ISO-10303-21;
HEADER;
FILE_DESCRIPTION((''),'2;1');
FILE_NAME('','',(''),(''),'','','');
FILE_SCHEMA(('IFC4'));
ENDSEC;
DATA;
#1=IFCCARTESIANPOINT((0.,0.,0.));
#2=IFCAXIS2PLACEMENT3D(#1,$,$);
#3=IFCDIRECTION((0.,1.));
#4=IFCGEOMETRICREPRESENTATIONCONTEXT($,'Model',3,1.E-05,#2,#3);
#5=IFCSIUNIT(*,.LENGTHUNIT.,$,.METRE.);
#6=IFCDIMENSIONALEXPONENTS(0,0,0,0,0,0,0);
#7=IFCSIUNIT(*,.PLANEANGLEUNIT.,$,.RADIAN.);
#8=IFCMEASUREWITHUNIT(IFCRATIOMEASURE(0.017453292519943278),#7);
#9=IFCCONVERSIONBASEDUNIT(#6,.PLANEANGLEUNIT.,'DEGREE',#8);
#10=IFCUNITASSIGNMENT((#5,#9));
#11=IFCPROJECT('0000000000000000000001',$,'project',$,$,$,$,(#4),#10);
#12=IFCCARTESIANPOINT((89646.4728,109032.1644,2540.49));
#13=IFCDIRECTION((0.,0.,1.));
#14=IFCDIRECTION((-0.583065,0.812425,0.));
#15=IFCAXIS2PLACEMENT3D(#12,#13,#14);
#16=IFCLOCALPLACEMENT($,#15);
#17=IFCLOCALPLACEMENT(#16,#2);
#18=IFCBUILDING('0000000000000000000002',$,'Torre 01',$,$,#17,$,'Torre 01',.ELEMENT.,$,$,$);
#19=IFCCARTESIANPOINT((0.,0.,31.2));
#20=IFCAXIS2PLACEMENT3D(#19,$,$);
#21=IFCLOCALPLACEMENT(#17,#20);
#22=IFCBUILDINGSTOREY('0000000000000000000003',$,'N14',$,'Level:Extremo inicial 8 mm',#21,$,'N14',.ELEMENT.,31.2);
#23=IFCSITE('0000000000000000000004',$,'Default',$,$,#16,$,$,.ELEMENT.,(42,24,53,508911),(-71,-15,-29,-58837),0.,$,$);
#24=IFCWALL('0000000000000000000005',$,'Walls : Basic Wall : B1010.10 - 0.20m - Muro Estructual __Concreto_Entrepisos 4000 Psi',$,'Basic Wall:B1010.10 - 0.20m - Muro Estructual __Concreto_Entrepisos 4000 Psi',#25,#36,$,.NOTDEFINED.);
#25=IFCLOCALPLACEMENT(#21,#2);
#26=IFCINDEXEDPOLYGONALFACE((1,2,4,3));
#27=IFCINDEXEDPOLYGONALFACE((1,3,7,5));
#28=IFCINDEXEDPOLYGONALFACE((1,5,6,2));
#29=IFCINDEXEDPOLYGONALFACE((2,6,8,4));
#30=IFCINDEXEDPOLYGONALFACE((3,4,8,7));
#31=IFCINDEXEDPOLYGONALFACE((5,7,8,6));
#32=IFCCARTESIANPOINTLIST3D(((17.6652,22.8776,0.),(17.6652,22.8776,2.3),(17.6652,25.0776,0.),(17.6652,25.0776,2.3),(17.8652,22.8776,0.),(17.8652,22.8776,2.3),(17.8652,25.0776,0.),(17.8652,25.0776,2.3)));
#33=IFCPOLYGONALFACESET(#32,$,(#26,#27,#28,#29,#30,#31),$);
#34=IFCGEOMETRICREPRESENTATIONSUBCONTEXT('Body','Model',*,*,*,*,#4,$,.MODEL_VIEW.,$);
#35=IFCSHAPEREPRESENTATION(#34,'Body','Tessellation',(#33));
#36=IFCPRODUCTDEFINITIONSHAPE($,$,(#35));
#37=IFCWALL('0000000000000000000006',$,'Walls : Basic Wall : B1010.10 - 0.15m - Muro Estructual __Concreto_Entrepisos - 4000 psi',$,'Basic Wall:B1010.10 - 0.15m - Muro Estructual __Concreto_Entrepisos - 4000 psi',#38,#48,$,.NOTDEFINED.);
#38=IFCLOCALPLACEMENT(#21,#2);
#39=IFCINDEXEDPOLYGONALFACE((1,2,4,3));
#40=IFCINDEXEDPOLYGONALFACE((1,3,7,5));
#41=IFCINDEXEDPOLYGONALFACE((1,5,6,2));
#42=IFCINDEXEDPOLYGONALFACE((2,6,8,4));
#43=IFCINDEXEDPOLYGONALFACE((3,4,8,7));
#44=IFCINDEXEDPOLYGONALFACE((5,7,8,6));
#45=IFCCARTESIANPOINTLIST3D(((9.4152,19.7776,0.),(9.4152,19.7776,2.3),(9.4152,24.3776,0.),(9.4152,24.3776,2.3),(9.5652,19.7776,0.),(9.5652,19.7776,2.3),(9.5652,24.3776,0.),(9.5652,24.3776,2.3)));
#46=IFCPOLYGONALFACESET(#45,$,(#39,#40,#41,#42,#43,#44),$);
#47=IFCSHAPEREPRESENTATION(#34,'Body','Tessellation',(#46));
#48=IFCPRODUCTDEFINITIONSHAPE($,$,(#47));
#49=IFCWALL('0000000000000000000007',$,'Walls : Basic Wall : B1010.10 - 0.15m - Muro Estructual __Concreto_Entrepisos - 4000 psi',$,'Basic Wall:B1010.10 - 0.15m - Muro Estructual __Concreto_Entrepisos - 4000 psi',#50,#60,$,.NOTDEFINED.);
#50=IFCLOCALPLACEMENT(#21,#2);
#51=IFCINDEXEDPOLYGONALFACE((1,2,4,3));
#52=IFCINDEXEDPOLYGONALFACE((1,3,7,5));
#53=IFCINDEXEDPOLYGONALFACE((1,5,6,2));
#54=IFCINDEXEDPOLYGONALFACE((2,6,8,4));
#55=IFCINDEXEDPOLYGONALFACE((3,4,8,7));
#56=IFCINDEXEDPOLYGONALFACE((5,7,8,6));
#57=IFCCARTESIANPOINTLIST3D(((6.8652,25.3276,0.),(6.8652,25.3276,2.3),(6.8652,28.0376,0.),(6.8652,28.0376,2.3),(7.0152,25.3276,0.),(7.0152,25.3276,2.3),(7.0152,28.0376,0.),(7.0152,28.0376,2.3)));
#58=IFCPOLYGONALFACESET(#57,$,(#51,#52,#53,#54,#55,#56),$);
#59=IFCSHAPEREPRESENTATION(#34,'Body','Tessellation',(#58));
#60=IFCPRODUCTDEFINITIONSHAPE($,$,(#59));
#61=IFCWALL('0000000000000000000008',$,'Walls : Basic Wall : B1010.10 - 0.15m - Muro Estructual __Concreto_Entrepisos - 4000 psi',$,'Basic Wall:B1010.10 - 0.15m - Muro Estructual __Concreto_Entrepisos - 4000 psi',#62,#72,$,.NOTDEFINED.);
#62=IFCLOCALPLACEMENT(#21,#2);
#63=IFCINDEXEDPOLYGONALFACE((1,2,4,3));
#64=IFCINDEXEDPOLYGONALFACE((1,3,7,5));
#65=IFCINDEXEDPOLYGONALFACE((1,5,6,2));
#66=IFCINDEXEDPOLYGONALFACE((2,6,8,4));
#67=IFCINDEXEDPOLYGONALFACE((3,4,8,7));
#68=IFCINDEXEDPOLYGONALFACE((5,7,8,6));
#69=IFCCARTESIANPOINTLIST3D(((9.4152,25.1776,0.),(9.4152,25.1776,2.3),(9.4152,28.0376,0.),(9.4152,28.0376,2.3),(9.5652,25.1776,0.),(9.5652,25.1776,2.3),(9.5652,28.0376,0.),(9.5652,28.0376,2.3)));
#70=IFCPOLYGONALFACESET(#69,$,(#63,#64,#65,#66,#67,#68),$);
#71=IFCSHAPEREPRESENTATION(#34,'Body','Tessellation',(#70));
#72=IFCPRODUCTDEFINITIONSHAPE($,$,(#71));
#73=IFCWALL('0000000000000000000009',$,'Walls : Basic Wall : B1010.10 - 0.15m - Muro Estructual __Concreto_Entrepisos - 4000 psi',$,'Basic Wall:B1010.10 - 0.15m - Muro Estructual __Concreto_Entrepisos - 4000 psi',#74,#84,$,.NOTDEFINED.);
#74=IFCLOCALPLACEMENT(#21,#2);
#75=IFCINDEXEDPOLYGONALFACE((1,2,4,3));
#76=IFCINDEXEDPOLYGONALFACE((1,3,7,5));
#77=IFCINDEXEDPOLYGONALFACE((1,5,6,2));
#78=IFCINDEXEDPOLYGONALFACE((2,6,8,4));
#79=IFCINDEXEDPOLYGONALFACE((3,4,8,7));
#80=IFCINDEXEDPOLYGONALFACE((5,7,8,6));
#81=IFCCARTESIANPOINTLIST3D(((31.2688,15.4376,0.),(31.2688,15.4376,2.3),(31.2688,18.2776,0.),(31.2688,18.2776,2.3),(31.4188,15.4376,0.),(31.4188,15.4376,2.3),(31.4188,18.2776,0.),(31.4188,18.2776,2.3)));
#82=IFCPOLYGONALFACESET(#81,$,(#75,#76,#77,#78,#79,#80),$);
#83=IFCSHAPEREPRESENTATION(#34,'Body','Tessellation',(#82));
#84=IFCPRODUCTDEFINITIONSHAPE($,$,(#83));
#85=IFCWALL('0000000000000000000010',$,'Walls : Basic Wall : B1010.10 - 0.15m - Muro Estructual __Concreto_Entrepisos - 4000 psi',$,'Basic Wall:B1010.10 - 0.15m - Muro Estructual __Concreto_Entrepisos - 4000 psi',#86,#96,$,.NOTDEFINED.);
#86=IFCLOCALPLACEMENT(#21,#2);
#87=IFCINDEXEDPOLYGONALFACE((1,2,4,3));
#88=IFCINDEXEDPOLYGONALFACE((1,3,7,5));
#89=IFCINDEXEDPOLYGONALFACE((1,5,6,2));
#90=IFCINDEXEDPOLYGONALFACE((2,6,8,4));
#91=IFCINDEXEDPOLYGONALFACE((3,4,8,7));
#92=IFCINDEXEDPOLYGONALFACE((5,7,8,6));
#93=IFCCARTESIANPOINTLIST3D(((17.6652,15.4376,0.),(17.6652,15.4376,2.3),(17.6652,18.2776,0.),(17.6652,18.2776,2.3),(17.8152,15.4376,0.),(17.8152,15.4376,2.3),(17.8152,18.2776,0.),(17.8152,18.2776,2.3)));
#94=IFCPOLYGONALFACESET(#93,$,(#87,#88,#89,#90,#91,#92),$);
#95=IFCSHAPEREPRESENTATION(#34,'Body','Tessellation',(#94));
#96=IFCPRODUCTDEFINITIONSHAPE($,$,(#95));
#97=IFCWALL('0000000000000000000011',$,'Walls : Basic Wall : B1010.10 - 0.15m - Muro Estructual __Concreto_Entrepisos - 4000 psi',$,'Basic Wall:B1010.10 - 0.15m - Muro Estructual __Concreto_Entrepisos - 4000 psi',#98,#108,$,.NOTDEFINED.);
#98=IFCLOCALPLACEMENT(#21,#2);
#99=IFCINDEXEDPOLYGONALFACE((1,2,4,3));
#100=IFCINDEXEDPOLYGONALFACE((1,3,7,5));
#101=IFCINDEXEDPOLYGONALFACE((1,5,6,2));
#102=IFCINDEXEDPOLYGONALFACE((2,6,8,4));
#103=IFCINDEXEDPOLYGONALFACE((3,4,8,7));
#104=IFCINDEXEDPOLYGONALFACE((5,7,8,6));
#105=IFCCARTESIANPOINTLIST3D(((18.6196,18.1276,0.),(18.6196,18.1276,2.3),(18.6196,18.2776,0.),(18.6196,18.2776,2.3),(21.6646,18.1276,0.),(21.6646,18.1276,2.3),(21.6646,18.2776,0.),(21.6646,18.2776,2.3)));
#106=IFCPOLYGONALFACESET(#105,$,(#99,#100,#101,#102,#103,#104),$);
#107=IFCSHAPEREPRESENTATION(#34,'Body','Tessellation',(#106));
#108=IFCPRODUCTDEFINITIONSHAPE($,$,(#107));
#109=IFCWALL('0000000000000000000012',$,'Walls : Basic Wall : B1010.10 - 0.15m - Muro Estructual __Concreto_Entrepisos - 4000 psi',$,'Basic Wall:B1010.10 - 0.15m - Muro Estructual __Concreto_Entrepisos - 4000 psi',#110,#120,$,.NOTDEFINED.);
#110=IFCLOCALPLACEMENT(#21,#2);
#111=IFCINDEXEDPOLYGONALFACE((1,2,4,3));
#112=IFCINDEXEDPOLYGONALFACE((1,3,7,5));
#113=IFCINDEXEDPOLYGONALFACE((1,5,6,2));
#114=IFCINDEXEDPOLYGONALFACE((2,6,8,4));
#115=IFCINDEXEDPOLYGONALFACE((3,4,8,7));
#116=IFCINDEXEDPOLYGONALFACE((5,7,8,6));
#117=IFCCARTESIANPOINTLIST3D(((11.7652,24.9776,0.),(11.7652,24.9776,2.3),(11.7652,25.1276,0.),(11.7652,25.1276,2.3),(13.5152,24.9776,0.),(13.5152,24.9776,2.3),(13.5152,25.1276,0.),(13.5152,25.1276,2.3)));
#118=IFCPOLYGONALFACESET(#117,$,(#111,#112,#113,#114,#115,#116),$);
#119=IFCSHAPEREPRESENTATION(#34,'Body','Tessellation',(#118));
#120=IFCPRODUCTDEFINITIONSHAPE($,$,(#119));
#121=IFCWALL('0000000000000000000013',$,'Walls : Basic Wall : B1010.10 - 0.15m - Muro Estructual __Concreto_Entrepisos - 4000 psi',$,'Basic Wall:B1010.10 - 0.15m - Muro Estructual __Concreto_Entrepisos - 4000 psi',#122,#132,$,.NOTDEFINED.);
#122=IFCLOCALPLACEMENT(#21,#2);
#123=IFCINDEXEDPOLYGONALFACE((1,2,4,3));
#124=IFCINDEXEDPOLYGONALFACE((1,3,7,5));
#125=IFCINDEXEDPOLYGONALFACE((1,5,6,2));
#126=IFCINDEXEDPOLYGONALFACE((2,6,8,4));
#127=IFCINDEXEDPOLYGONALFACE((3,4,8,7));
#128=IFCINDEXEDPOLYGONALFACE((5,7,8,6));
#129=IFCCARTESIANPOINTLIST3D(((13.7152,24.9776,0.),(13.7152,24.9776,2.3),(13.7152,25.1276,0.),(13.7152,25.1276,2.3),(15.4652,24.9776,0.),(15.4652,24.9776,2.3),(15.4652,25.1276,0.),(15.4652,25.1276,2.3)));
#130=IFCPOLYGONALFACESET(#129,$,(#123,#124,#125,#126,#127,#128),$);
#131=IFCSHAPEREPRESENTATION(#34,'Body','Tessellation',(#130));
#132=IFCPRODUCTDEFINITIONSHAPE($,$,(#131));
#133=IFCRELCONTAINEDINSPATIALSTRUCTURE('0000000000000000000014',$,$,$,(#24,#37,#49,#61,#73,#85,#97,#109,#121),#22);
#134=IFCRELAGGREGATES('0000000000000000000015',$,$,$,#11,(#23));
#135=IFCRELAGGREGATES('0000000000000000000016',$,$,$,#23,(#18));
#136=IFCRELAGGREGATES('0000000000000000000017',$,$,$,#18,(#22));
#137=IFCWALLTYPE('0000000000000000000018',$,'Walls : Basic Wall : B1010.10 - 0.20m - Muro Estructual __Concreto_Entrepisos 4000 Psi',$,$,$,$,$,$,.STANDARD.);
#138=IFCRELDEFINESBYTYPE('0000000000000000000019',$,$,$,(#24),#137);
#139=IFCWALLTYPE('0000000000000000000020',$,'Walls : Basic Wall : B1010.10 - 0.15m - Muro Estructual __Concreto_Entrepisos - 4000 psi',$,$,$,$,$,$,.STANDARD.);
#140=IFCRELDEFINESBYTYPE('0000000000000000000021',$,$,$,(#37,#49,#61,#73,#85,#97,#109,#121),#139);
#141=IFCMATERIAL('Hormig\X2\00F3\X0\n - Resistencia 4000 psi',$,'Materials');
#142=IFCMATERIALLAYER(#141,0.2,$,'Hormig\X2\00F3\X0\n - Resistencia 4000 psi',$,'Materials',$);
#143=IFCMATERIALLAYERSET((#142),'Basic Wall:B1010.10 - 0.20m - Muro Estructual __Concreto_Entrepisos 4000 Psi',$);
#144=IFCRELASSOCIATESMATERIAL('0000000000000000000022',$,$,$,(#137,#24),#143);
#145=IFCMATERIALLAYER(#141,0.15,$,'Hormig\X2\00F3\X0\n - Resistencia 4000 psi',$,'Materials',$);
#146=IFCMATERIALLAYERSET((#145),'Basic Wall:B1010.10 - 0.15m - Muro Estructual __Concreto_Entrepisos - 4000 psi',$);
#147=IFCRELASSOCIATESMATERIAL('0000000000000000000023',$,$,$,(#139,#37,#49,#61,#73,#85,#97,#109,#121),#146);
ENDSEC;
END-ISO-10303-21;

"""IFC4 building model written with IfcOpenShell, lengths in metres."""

from ifc_helpers import new_model, entity, si_unit, converted_unit, direction, frame, frame_2d, origin, place, context, subcontext, project, spatial, rectangle, extrude, material, layer, layer_set, layer_usage, type_object, element, save


model = new_model("IFC4")

# Units and contexts
model_context = context("Model", 3, precision=1e-05, world=origin(), true_north=direction((0.0, 1.0)))
body_context = subcontext(model_context, "Body", "Model", "MODEL_VIEW")
ifc_project = project(units=[si_unit("LENGTHUNIT", "METRE"), converted_unit("PLANEANGLEUNIT", "DEGREE", entity("IfcRatioMeasure", 0.017453292519943278), si_unit("PLANEANGLEUNIT", "RADIAN"), dimensions=[0, 0, 0, 0, 0, 0, 0])], contexts=[model_context])

# Site, building, storey
site_placement = place(None, frame((89646.4728, 109032.1644, 2540.49), z_axis=(0.0, 0.0, 1.0), x_axis=(-0.583065, 0.812425, 0.0)))
site = spatial("IfcSite", under=ifc_project, at=site_placement, Name="Default", CompositionType="ELEMENT", RefLatitude=(42, 24, 53, 508911), RefLongitude=(-71, -15, -29, -58837), RefElevation=0.0)
building_placement = place(site_placement, origin())
building = spatial("IfcBuilding", under=site, at=building_placement, Name="Torre 01", LongName="Torre 01", CompositionType="ELEMENT")
storey_placement = place(building_placement, frame((0.0, 0.0, 31.2)))
storey = spatial("IfcBuildingStorey", under=building, at=storey_placement, Name="N14", ObjectType="Level:Extremo inicial 8 mm", LongName="N14", CompositionType="ELEMENT", Elevation=31.2)

# Walls
ifc_material = material(Name="Hormigón - Resistencia 4000 psi", Category="Materials")
ifc_layer_1 = layer(ifc_material, 0.2, Name="Hormigón - Resistencia 4000 psi", Category="Materials")
ifc_layer_set_1 = layer_set([ifc_layer_1], Name="Basic Wall:B1010.10 - 0.20m - Muro Estructual __Concreto_Entrepisos 4000 Psi")
wall_type_1 = type_object("IfcWallType", Name="Walls : Basic Wall : B1010.10 - 0.20m - Muro Estructual __Concreto_Entrepisos 4000 Psi", PredefinedType="STANDARD", material=ifc_layer_set_1)
ifc_layer_usage_1 = layer_usage(ifc_layer_set_1, "AXIS2", "NEGATIVE", 0.1)
wall_1_placement = place(storey_placement, frame((17.7652, 22.8776, 0.0), z_axis=(0.0, 0.0, 1.0), x_axis=(0.0, 1.0, 0.0)))
element("IfcWall", 1, at=wall_1_placement, inside=storey, type_object=wall_type_1, material=ifc_layer_usage_1, Name="Walls : Basic Wall : B1010.10 - 0.20m - Muro Estructual __Concreto_Entrepisos 4000 Psi", ObjectType="Basic Wall:B1010.10 - 0.20m - Muro Estructual __Concreto_Entrepisos 4000 Psi", PredefinedType="NOTDEFINED", context=body_context, shape_type="SweptSolid", body=[
    extrude(rectangle(XDim=2.2, YDim=0.2, at=frame_2d((1.1, 0.0), x_axis=(-1.0, 0.0))), origin(), (0.0, 0.0, 1.0), 2.3),
])
ifc_layer_2 = layer(ifc_material, 0.15, Name="Hormigón - Resistencia 4000 psi", Category="Materials")
ifc_layer_set_2 = layer_set([ifc_layer_2], Name="Basic Wall:B1010.10 - 0.15m - Muro Estructual __Concreto_Entrepisos - 4000 psi")
ifc_layer_usage_2 = layer_usage(ifc_layer_set_2, "AXIS2", "NEGATIVE", 0.075)
wall_type_2 = type_object("IfcWallType", Name="Walls : Basic Wall : B1010.10 - 0.15m - Muro Estructual __Concreto_Entrepisos - 4000 psi", PredefinedType="STANDARD", material=ifc_layer_set_2)
wall_2_placement = place(storey_placement, frame((9.4902, 24.3776, 0.0), z_axis=(0.0, 0.0, 1.0), x_axis=(0.0, -1.0, 0.0)))
element("IfcWall", 2, at=wall_2_placement, inside=storey, type_object=wall_type_2, material=ifc_layer_usage_2, Name="Walls : Basic Wall : B1010.10 - 0.15m - Muro Estructual __Concreto_Entrepisos - 4000 psi", ObjectType="Basic Wall:B1010.10 - 0.15m - Muro Estructual __Concreto_Entrepisos - 4000 psi", PredefinedType="NOTDEFINED", context=body_context, shape_type="SweptSolid", body=[
    extrude(rectangle(XDim=4.6, YDim=0.15, at=frame_2d((2.3, 0.0), x_axis=(-1.0, 0.0))), origin(), (0.0, 0.0, 1.0), 2.3),
])
ifc_layer_usage_3 = layer_usage(ifc_layer_set_2, "AXIS2", "NEGATIVE", 0.075)
wall_3_placement = place(storey_placement, frame((6.9402, 25.3276, 0.0), z_axis=(0.0, 0.0, 1.0), x_axis=(0.0, 1.0, 0.0)))
element("IfcWall", 3, at=wall_3_placement, inside=storey, type_object=wall_type_2, material=ifc_layer_usage_3, Name="Walls : Basic Wall : B1010.10 - 0.15m - Muro Estructual __Concreto_Entrepisos - 4000 psi", ObjectType="Basic Wall:B1010.10 - 0.15m - Muro Estructual __Concreto_Entrepisos - 4000 psi", PredefinedType="NOTDEFINED", context=body_context, shape_type="SweptSolid", body=[
    extrude(rectangle(XDim=2.71, YDim=0.15, at=frame_2d((1.355, 0.0), x_axis=(-1.0, 0.0))), origin(), (0.0, 0.0, 1.0), 2.3),
])
ifc_layer_usage_4 = layer_usage(ifc_layer_set_2, "AXIS2", "NEGATIVE", 0.075)
wall_4_placement = place(storey_placement, frame((9.4902, 28.0376, 0.0), z_axis=(0.0, 0.0, 1.0), x_axis=(0.0, -1.0, 0.0)))
element("IfcWall", 4, at=wall_4_placement, inside=storey, type_object=wall_type_2, material=ifc_layer_usage_4, Name="Walls : Basic Wall : B1010.10 - 0.15m - Muro Estructual __Concreto_Entrepisos - 4000 psi", ObjectType="Basic Wall:B1010.10 - 0.15m - Muro Estructual __Concreto_Entrepisos - 4000 psi", PredefinedType="NOTDEFINED", context=body_context, shape_type="SweptSolid", body=[
    extrude(rectangle(XDim=2.86, YDim=0.15, at=frame_2d((1.43, 0.0), x_axis=(-1.0, 0.0))), origin(), (0.0, 0.0, 1.0), 2.3),
])
ifc_layer_usage_5 = layer_usage(ifc_layer_set_2, "AXIS2", "NEGATIVE", 0.075)
wall_5_placement = place(storey_placement, frame((31.3438, 15.4376, 0.0), z_axis=(0.0, 0.0, 1.0), x_axis=(0.0, 1.0, 0.0)))
element("IfcWall", 5, at=wall_5_placement, inside=storey, type_object=wall_type_2, material=ifc_layer_usage_5, Name="Walls : Basic Wall : B1010.10 - 0.15m - Muro Estructual __Concreto_Entrepisos - 4000 psi", ObjectType="Basic Wall:B1010.10 - 0.15m - Muro Estructual __Concreto_Entrepisos - 4000 psi", PredefinedType="NOTDEFINED", context=body_context, shape_type="SweptSolid", body=[
    extrude(rectangle(XDim=2.84, YDim=0.15, at=frame_2d((1.42, 0.0), x_axis=(-1.0, 0.0))), origin(), (0.0, 0.0, 1.0), 2.3),
])
ifc_layer_usage_6 = layer_usage(ifc_layer_set_2, "AXIS2", "NEGATIVE", 0.075)
wall_6_placement = place(storey_placement, frame((17.7402, 18.2776, 0.0), z_axis=(0.0, 0.0, 1.0), x_axis=(0.0, -1.0, 0.0)))
element("IfcWall", 6, at=wall_6_placement, inside=storey, type_object=wall_type_2, material=ifc_layer_usage_6, Name="Walls : Basic Wall : B1010.10 - 0.15m - Muro Estructual __Concreto_Entrepisos - 4000 psi", ObjectType="Basic Wall:B1010.10 - 0.15m - Muro Estructual __Concreto_Entrepisos - 4000 psi", PredefinedType="NOTDEFINED", context=body_context, shape_type="SweptSolid", body=[
    extrude(rectangle(XDim=2.84, YDim=0.15, at=frame_2d((1.42, 0.0), x_axis=(-1.0, 0.0))), origin(), (0.0, 0.0, 1.0), 2.3),
])
ifc_layer_usage_7 = layer_usage(ifc_layer_set_2, "AXIS2", "NEGATIVE", 0.075)
wall_7_placement = place(storey_placement, frame((18.6196, 18.2026, 0.0)))
element("IfcWall", 7, at=wall_7_placement, inside=storey, type_object=wall_type_2, material=ifc_layer_usage_7, Name="Walls : Basic Wall : B1010.10 - 0.15m - Muro Estructual __Concreto_Entrepisos - 4000 psi", ObjectType="Basic Wall:B1010.10 - 0.15m - Muro Estructual __Concreto_Entrepisos - 4000 psi", PredefinedType="NOTDEFINED", context=body_context, shape_type="SweptSolid", body=[
    extrude(rectangle(XDim=3.045, YDim=0.15, at=frame_2d((1.5225, 0.0), x_axis=(-1.0, 0.0))), origin(), (0.0, 0.0, 1.0), 2.3),
])
ifc_layer_usage_8 = layer_usage(ifc_layer_set_2, "AXIS2", "POSITIVE", -0.075)
wall_8_placement = place(storey_placement, frame((11.7652, 25.0526, 0.0)))
element("IfcWall", 8, at=wall_8_placement, inside=storey, type_object=wall_type_2, material=ifc_layer_usage_8, Name="Walls : Basic Wall : B1010.10 - 0.15m - Muro Estructual __Concreto_Entrepisos - 4000 psi", ObjectType="Basic Wall:B1010.10 - 0.15m - Muro Estructual __Concreto_Entrepisos - 4000 psi", PredefinedType="NOTDEFINED", context=body_context, shape_type="SweptSolid", body=[
    extrude(rectangle(XDim=1.75, YDim=0.15, at=frame_2d((0.875, 0.0), x_axis=(-1.0, 0.0))), origin(), (0.0, 0.0, 1.0), 2.3),
])
ifc_layer_usage_9 = layer_usage(ifc_layer_set_2, "AXIS2", "POSITIVE", -0.075)
wall_9_placement = place(storey_placement, frame((13.7152, 25.0526, 0.0)))
element("IfcWall", 9, at=wall_9_placement, inside=storey, type_object=wall_type_2, material=ifc_layer_usage_9, Name="Walls : Basic Wall : B1010.10 - 0.15m - Muro Estructual __Concreto_Entrepisos - 4000 psi", ObjectType="Basic Wall:B1010.10 - 0.15m - Muro Estructual __Concreto_Entrepisos - 4000 psi", PredefinedType="NOTDEFINED", context=body_context, shape_type="SweptSolid", body=[
    extrude(rectangle(XDim=1.75, YDim=0.15, at=frame_2d((0.875, 0.0), x_axis=(-1.0, 0.0))), origin(), (0.0, 0.0, 1.0), 2.3),
])

save(model, "model.ifc")
